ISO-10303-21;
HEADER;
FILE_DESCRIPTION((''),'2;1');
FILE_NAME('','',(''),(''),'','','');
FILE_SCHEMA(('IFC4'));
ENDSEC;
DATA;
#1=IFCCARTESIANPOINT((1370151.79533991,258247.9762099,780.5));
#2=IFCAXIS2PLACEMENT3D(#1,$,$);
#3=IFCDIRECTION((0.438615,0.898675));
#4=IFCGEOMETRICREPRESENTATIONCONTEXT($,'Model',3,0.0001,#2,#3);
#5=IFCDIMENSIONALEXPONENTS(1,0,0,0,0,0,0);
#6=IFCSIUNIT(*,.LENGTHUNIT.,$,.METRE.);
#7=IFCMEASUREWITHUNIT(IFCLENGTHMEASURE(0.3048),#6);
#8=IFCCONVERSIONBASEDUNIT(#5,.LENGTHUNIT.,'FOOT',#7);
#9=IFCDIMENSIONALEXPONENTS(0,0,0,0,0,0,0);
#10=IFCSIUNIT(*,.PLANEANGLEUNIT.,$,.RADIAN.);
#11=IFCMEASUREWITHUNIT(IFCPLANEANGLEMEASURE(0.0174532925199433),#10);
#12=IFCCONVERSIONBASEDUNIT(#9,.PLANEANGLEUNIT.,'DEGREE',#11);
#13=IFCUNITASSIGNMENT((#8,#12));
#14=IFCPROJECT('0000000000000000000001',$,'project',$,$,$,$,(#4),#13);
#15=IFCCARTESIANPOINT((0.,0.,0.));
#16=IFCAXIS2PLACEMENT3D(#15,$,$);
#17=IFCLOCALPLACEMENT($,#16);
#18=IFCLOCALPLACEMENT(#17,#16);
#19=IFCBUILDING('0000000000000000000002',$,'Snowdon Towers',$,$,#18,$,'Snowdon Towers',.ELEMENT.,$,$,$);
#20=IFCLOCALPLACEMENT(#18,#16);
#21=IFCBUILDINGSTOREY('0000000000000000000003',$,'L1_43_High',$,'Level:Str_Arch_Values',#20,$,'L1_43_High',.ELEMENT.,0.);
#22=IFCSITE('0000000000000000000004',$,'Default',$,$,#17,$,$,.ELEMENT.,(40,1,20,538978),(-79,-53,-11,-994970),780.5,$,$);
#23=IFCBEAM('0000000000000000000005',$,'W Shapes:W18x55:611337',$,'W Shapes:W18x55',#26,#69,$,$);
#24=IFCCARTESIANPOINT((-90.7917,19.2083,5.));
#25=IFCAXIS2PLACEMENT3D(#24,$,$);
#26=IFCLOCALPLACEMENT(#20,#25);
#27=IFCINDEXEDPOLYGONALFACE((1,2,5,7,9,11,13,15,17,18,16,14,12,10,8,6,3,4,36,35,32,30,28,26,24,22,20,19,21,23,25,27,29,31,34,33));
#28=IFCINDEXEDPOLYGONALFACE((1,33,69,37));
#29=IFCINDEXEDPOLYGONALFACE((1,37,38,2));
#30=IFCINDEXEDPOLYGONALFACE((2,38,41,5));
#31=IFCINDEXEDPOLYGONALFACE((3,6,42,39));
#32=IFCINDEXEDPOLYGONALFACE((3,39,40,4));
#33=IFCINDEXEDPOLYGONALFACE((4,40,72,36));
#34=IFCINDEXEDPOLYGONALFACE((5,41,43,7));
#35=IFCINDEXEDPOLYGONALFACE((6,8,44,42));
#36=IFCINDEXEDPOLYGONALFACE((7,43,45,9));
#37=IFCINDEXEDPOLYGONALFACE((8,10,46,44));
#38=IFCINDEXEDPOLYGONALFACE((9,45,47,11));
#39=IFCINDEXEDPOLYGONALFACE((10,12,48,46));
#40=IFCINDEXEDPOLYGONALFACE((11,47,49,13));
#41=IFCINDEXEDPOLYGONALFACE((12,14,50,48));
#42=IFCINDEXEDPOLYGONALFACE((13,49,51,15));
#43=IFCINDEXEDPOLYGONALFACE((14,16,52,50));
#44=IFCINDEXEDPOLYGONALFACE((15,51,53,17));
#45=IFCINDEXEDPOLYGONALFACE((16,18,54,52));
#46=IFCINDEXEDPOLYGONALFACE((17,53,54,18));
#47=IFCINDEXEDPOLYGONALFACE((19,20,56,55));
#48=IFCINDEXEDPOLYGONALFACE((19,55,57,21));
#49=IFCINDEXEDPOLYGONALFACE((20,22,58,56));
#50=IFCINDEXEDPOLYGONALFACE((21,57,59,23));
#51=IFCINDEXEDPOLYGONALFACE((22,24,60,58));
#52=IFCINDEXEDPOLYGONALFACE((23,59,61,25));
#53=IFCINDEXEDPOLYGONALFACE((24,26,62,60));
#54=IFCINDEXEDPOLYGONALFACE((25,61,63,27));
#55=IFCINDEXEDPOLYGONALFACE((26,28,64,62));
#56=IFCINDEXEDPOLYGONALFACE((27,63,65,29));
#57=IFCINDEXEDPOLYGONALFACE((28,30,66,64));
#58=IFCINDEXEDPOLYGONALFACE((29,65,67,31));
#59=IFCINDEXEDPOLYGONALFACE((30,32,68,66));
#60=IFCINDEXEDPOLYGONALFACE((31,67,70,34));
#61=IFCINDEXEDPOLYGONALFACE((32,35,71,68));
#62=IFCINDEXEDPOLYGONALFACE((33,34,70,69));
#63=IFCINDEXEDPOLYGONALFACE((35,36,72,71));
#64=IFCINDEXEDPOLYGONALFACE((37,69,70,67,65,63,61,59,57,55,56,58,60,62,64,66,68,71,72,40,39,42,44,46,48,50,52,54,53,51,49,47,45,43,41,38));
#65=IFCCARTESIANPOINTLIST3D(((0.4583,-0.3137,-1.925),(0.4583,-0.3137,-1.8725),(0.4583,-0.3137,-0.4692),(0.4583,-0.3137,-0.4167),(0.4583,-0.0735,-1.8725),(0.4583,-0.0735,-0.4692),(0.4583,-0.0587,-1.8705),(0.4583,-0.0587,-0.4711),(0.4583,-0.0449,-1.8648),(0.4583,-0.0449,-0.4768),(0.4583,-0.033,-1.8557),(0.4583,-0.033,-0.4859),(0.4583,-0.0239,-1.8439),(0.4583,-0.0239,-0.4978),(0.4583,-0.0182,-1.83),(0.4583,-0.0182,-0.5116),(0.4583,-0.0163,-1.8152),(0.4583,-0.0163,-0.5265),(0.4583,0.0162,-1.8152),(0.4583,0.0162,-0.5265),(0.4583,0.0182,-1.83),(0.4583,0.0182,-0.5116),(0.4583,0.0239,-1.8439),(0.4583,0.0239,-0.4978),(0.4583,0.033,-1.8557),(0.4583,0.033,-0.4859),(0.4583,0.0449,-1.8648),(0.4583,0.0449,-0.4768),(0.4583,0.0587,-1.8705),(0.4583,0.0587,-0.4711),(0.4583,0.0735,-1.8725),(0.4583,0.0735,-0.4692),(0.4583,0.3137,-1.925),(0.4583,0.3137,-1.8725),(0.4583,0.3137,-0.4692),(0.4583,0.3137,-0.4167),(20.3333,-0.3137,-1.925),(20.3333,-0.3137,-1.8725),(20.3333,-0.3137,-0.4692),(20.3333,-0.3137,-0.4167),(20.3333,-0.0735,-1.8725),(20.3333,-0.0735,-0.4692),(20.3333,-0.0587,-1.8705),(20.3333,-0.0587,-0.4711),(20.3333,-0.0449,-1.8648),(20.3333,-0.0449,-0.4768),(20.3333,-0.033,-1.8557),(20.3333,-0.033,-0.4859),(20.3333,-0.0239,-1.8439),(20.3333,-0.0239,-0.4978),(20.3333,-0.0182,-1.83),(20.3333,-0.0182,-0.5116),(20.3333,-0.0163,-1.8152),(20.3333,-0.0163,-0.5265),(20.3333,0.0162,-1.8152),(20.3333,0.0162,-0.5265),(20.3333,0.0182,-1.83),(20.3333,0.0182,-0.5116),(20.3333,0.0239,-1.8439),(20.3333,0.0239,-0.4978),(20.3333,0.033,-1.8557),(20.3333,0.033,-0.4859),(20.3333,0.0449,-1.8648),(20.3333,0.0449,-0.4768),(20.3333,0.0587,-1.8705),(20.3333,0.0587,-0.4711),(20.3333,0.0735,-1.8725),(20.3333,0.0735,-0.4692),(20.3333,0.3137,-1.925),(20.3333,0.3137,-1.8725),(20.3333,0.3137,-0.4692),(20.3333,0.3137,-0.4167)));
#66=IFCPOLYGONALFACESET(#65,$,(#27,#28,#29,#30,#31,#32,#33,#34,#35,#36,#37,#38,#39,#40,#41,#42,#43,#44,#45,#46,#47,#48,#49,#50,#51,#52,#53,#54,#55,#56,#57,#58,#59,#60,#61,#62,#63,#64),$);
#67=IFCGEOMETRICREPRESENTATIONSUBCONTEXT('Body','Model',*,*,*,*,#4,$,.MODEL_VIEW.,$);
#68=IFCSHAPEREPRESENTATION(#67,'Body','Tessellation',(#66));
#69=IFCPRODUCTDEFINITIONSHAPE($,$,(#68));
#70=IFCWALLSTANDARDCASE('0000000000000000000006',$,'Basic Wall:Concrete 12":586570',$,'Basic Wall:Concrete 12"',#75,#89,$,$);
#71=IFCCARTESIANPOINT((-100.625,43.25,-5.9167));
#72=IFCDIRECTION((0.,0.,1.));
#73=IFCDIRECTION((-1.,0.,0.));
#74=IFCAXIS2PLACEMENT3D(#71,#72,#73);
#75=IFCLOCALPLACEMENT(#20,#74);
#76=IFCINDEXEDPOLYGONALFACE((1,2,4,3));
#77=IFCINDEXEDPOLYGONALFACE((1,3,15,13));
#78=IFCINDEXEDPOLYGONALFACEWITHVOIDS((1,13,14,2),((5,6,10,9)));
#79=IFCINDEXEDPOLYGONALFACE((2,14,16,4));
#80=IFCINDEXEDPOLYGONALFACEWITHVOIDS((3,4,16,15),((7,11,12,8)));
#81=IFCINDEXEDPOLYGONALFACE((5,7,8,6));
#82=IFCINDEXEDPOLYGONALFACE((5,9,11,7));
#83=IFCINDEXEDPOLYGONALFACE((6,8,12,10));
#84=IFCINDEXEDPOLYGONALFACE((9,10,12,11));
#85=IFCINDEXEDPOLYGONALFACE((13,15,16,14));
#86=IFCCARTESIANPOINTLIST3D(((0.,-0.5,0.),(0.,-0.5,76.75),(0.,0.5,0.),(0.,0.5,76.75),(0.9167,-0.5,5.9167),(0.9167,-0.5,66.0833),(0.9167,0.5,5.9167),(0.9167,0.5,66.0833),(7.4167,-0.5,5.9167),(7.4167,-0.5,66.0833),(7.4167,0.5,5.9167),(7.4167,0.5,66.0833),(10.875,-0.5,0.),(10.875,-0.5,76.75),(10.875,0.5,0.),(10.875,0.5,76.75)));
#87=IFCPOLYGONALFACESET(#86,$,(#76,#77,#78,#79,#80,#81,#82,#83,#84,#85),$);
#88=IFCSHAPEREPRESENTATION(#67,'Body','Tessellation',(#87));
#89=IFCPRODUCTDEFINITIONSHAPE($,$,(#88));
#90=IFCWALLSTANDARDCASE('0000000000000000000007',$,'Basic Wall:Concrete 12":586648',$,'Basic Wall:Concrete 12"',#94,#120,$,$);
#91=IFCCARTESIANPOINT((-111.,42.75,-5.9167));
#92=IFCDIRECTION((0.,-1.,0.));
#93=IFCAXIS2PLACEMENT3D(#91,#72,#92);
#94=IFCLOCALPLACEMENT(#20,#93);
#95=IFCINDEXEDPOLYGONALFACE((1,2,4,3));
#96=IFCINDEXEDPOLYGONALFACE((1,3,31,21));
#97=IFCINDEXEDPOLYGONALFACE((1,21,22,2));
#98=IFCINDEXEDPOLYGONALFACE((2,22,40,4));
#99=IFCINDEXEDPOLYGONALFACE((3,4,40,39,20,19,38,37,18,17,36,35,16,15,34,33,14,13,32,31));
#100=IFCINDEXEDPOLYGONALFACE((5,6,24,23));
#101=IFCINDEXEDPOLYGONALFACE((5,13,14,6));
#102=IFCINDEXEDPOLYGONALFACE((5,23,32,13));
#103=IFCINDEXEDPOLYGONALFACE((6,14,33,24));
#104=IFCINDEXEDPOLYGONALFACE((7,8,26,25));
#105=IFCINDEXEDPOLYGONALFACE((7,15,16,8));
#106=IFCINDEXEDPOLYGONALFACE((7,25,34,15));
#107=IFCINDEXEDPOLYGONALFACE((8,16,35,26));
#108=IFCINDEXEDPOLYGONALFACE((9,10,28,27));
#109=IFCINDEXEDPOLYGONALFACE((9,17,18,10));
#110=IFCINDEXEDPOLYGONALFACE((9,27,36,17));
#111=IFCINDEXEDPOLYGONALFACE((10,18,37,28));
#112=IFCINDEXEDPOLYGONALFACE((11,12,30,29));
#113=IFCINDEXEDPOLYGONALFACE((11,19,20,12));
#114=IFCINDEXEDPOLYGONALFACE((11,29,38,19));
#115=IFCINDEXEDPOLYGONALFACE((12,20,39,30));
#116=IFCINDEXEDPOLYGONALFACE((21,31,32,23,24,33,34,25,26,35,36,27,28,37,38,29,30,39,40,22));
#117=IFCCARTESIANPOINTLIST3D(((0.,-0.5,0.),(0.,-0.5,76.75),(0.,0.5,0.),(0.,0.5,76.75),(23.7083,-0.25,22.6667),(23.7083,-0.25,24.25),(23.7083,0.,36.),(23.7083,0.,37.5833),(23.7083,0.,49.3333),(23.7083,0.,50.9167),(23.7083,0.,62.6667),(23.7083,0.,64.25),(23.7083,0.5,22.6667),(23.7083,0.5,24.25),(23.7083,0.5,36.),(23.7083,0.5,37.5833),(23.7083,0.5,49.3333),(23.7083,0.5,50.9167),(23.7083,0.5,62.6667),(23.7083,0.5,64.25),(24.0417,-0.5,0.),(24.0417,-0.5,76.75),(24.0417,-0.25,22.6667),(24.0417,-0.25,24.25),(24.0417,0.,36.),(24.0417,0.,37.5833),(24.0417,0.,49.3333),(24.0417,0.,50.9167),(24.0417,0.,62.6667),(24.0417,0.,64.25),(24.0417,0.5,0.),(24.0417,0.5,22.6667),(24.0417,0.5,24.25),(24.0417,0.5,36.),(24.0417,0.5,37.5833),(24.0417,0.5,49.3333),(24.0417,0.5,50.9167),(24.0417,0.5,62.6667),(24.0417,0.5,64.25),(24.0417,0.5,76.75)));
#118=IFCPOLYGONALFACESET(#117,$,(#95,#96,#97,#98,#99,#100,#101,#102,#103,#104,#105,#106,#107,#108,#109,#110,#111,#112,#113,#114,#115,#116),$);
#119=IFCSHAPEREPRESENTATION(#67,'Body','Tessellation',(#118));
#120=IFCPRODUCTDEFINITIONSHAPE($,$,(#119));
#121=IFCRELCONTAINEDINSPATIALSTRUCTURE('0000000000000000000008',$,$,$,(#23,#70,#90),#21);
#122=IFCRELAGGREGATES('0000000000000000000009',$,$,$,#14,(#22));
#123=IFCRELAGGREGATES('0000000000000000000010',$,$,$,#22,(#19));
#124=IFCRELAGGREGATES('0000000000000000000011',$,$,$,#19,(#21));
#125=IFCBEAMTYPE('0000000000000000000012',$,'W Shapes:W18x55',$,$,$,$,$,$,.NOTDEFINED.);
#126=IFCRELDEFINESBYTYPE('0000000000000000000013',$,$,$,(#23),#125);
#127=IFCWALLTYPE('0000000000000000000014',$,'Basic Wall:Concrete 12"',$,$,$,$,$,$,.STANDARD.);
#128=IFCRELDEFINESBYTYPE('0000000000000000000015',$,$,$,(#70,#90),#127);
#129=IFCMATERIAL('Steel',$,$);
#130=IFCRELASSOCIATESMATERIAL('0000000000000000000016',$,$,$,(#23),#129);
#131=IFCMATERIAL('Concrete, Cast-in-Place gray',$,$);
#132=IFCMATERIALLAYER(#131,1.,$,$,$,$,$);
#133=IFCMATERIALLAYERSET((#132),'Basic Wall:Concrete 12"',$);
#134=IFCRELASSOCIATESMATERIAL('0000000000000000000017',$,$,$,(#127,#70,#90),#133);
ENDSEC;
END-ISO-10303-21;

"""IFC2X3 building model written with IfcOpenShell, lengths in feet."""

from ifc_helpers import new_model, entity, si_unit, converted_unit, direction, frame, frame_2d, origin, place, context, subcontext, project, spatial, rectangle, i_section, extrude, material, layer, layer_set, layer_usage, type_object, element, save


model = new_model("IFC2X3")

# Units and contexts
model_context = context("Model", 3, precision=0.0001, world=frame((1370151.79533991, 258247.9762099, 780.5)), true_north=direction((0.438615, 0.898675)))
body_context = subcontext(model_context, "Body", "Model", "MODEL_VIEW")
ifc_project = project(units=[converted_unit("LENGTHUNIT", "FOOT", entity("IfcLengthMeasure", 0.3048), si_unit("LENGTHUNIT", "METRE"), dimensions=[1, 0, 0, 0, 0, 0, 0]), converted_unit("PLANEANGLEUNIT", "DEGREE", entity("IfcPlaneAngleMeasure", 0.0174532925199433), si_unit("PLANEANGLEUNIT", "RADIAN"), dimensions=[0, 0, 0, 0, 0, 0, 0])], contexts=[model_context])

# Site, building, storey
site_placement = place(None, origin())
site = spatial("IfcSite", under=ifc_project, at=site_placement, Name="Default", CompositionType="ELEMENT", RefLatitude=(40, 1, 20, 538978), RefLongitude=(-79, -53, -11, -994970), RefElevation=780.5)
building_placement = place(site_placement, origin())
building = spatial("IfcBuilding", under=site, at=building_placement, Name="Snowdon Towers", LongName="Snowdon Towers", CompositionType="ELEMENT")
storey_placement = place(building_placement, origin())
storey = spatial("IfcBuildingStorey", under=building, at=storey_placement, Name="L1_43_High", ObjectType="Level:Str_Arch_Values", LongName="L1_43_High", CompositionType="ELEMENT", Elevation=0.0)

# Beam
ifc_material_1 = material(Name="Steel")
beam_type = type_object("IfcBeamType", Name="W Shapes:W18x55", PredefinedType="NOTDEFINED")
beam_1_placement = place(storey_placement, frame((-90.7917, 19.2083, 5.0)))
element("IfcBeam", 1, at=beam_1_placement, inside=storey, type_object=beam_type, material=ifc_material_1, Name="W Shapes:W18x55:611337", ObjectType="W Shapes:W18x55", context=body_context, shape_type="SweptSolid", body=[
    extrude(i_section(OverallWidth=0.6275, OverallDepth=1.5083, WebThickness=0.0325, FlangeThickness=0.0525, FilletRadius=0.0573, at=frame_2d((0.0, 0.0), x_axis=(0.0, 1.0))), frame((0.4583, 0.0, -1.1708), z_axis=(1.0, 0.0, 0.0), x_axis=(0.0, 0.0, -1.0)), (0.0, 0.0, 1.0), 19.875),
])

# Wall, opening
ifc_material_2 = material(Name="Concrete, Cast-in-Place gray")
ifc_layer = layer(ifc_material_2, 1.0)
ifc_layer_set = layer_set([ifc_layer], Name="Basic Wall:Concrete 12\"")
ifc_layer_usage_1 = layer_usage(ifc_layer_set, "AXIS2", "POSITIVE", -0.5)
wall_type = type_object("IfcWallType", Name="Basic Wall:Concrete 12\"", PredefinedType="STANDARD", material=ifc_layer_set)
wall_1_placement = place(storey_placement, frame((-100.625, 43.25, -5.9167), z_axis=(0.0, 0.0, 1.0), x_axis=(-1.0, 0.0, 0.0)))
wall_1 = element("IfcWallStandardCase", 2, at=wall_1_placement, inside=storey, type_object=wall_type, material=ifc_layer_usage_1, Name="Basic Wall:Concrete 12\":586570", ObjectType="Basic Wall:Concrete 12\"", context=body_context, shape_type="SweptSolid", body=[
    extrude(rectangle(XDim=10.875, YDim=1.0, at=frame_2d((5.4375, 0.0), x_axis=(-1.0, 0.0))), origin(), (0.0, 0.0, 1.0), 76.75),
])
opening_1_placement = place(wall_1_placement, origin())
element("IfcOpeningElement", 3, at=opening_1_placement, cuts=wall_1, ObjectType="Opening", context=body_context, shape_type="SweptSolid", body=[
    extrude(rectangle(XDim=60.1667, YDim=6.5, at=frame_2d((0.0, 0.0), x_axis=(1.0, 0.0))), frame((4.1667, -4.5, 36.0), z_axis=(0.0, 1.0, 0.0), x_axis=(0.0, 0.0, 1.0)), (0.0, 0.0, 1.0), 10.0),
])

# Wall, openings
ifc_layer_usage_2 = layer_usage(ifc_layer_set, "AXIS2", "POSITIVE", -0.5)
wall_2_placement = place(storey_placement, frame((-111.0, 42.75, -5.9167), z_axis=(0.0, 0.0, 1.0), x_axis=(0.0, -1.0, 0.0)))
wall_2 = element("IfcWallStandardCase", 4, at=wall_2_placement, inside=storey, type_object=wall_type, material=ifc_layer_usage_2, Name="Basic Wall:Concrete 12\":586648", ObjectType="Basic Wall:Concrete 12\"", context=body_context, shape_type="SweptSolid", body=[
    extrude(rectangle(XDim=24.0417, YDim=1.0, at=frame_2d((12.0208, 0.0), x_axis=(-1.0, 0.0))), origin(), (0.0, 0.0, 1.0), 76.75),
])
opening_2_placement = place(wall_2_placement, origin())
element("IfcOpeningElement", 5, at=opening_2_placement, cuts=wall_2, ObjectType="Opening", context=body_context, shape_type="SweptSolid", body=[
    extrude(rectangle(XDim=1.5833, YDim=0.3333, at=frame_2d((0.0, 0.0), x_axis=(0.0, 1.0))), frame((23.875, -0.25, 23.4583), z_axis=(0.0, 1.0, 0.0), x_axis=(1.0, 0.0, 0.0)), (0.0, 0.0, 1.0), 1.0),
])
opening_3_placement = place(wall_2_placement, origin())
element("IfcOpeningElement", 6, at=opening_3_placement, cuts=wall_2, ObjectType="Opening", context=body_context, shape_type="SweptSolid", body=[
    extrude(rectangle(XDim=1.5833, YDim=0.3333, at=frame_2d((0.0, 0.0), x_axis=(0.0, 1.0))), frame((23.875, 0.0, 63.4583), z_axis=(0.0, 1.0, 0.0), x_axis=(1.0, 0.0, 0.0)), (0.0, 0.0, 1.0), 1.0),
])
opening_4_placement = place(wall_2_placement, origin())
element("IfcOpeningElement", 7, at=opening_4_placement, cuts=wall_2, ObjectType="Opening", context=body_context, shape_type="SweptSolid", body=[
    extrude(rectangle(XDim=1.5833, YDim=0.3333, at=frame_2d((0.0, 0.0), x_axis=(0.0, 1.0))), frame((23.875, 0.0, 36.7917), z_axis=(0.0, 1.0, 0.0), x_axis=(1.0, 0.0, 0.0)), (0.0, 0.0, 1.0), 1.0),
])
opening_5_placement = place(wall_2_placement, origin())
element("IfcOpeningElement", 8, at=opening_5_placement, cuts=wall_2, ObjectType="Opening", context=body_context, shape_type="SweptSolid", body=[
    extrude(rectangle(XDim=1.5833, YDim=0.3333, at=frame_2d((0.0, 0.0), x_axis=(0.0, 1.0))), frame((23.875, 0.0, 50.125), z_axis=(0.0, 1.0, 0.0), x_axis=(1.0, 0.0, 0.0)), (0.0, 0.0, 1.0), 1.0),
])

save(model, "model.ifc")
